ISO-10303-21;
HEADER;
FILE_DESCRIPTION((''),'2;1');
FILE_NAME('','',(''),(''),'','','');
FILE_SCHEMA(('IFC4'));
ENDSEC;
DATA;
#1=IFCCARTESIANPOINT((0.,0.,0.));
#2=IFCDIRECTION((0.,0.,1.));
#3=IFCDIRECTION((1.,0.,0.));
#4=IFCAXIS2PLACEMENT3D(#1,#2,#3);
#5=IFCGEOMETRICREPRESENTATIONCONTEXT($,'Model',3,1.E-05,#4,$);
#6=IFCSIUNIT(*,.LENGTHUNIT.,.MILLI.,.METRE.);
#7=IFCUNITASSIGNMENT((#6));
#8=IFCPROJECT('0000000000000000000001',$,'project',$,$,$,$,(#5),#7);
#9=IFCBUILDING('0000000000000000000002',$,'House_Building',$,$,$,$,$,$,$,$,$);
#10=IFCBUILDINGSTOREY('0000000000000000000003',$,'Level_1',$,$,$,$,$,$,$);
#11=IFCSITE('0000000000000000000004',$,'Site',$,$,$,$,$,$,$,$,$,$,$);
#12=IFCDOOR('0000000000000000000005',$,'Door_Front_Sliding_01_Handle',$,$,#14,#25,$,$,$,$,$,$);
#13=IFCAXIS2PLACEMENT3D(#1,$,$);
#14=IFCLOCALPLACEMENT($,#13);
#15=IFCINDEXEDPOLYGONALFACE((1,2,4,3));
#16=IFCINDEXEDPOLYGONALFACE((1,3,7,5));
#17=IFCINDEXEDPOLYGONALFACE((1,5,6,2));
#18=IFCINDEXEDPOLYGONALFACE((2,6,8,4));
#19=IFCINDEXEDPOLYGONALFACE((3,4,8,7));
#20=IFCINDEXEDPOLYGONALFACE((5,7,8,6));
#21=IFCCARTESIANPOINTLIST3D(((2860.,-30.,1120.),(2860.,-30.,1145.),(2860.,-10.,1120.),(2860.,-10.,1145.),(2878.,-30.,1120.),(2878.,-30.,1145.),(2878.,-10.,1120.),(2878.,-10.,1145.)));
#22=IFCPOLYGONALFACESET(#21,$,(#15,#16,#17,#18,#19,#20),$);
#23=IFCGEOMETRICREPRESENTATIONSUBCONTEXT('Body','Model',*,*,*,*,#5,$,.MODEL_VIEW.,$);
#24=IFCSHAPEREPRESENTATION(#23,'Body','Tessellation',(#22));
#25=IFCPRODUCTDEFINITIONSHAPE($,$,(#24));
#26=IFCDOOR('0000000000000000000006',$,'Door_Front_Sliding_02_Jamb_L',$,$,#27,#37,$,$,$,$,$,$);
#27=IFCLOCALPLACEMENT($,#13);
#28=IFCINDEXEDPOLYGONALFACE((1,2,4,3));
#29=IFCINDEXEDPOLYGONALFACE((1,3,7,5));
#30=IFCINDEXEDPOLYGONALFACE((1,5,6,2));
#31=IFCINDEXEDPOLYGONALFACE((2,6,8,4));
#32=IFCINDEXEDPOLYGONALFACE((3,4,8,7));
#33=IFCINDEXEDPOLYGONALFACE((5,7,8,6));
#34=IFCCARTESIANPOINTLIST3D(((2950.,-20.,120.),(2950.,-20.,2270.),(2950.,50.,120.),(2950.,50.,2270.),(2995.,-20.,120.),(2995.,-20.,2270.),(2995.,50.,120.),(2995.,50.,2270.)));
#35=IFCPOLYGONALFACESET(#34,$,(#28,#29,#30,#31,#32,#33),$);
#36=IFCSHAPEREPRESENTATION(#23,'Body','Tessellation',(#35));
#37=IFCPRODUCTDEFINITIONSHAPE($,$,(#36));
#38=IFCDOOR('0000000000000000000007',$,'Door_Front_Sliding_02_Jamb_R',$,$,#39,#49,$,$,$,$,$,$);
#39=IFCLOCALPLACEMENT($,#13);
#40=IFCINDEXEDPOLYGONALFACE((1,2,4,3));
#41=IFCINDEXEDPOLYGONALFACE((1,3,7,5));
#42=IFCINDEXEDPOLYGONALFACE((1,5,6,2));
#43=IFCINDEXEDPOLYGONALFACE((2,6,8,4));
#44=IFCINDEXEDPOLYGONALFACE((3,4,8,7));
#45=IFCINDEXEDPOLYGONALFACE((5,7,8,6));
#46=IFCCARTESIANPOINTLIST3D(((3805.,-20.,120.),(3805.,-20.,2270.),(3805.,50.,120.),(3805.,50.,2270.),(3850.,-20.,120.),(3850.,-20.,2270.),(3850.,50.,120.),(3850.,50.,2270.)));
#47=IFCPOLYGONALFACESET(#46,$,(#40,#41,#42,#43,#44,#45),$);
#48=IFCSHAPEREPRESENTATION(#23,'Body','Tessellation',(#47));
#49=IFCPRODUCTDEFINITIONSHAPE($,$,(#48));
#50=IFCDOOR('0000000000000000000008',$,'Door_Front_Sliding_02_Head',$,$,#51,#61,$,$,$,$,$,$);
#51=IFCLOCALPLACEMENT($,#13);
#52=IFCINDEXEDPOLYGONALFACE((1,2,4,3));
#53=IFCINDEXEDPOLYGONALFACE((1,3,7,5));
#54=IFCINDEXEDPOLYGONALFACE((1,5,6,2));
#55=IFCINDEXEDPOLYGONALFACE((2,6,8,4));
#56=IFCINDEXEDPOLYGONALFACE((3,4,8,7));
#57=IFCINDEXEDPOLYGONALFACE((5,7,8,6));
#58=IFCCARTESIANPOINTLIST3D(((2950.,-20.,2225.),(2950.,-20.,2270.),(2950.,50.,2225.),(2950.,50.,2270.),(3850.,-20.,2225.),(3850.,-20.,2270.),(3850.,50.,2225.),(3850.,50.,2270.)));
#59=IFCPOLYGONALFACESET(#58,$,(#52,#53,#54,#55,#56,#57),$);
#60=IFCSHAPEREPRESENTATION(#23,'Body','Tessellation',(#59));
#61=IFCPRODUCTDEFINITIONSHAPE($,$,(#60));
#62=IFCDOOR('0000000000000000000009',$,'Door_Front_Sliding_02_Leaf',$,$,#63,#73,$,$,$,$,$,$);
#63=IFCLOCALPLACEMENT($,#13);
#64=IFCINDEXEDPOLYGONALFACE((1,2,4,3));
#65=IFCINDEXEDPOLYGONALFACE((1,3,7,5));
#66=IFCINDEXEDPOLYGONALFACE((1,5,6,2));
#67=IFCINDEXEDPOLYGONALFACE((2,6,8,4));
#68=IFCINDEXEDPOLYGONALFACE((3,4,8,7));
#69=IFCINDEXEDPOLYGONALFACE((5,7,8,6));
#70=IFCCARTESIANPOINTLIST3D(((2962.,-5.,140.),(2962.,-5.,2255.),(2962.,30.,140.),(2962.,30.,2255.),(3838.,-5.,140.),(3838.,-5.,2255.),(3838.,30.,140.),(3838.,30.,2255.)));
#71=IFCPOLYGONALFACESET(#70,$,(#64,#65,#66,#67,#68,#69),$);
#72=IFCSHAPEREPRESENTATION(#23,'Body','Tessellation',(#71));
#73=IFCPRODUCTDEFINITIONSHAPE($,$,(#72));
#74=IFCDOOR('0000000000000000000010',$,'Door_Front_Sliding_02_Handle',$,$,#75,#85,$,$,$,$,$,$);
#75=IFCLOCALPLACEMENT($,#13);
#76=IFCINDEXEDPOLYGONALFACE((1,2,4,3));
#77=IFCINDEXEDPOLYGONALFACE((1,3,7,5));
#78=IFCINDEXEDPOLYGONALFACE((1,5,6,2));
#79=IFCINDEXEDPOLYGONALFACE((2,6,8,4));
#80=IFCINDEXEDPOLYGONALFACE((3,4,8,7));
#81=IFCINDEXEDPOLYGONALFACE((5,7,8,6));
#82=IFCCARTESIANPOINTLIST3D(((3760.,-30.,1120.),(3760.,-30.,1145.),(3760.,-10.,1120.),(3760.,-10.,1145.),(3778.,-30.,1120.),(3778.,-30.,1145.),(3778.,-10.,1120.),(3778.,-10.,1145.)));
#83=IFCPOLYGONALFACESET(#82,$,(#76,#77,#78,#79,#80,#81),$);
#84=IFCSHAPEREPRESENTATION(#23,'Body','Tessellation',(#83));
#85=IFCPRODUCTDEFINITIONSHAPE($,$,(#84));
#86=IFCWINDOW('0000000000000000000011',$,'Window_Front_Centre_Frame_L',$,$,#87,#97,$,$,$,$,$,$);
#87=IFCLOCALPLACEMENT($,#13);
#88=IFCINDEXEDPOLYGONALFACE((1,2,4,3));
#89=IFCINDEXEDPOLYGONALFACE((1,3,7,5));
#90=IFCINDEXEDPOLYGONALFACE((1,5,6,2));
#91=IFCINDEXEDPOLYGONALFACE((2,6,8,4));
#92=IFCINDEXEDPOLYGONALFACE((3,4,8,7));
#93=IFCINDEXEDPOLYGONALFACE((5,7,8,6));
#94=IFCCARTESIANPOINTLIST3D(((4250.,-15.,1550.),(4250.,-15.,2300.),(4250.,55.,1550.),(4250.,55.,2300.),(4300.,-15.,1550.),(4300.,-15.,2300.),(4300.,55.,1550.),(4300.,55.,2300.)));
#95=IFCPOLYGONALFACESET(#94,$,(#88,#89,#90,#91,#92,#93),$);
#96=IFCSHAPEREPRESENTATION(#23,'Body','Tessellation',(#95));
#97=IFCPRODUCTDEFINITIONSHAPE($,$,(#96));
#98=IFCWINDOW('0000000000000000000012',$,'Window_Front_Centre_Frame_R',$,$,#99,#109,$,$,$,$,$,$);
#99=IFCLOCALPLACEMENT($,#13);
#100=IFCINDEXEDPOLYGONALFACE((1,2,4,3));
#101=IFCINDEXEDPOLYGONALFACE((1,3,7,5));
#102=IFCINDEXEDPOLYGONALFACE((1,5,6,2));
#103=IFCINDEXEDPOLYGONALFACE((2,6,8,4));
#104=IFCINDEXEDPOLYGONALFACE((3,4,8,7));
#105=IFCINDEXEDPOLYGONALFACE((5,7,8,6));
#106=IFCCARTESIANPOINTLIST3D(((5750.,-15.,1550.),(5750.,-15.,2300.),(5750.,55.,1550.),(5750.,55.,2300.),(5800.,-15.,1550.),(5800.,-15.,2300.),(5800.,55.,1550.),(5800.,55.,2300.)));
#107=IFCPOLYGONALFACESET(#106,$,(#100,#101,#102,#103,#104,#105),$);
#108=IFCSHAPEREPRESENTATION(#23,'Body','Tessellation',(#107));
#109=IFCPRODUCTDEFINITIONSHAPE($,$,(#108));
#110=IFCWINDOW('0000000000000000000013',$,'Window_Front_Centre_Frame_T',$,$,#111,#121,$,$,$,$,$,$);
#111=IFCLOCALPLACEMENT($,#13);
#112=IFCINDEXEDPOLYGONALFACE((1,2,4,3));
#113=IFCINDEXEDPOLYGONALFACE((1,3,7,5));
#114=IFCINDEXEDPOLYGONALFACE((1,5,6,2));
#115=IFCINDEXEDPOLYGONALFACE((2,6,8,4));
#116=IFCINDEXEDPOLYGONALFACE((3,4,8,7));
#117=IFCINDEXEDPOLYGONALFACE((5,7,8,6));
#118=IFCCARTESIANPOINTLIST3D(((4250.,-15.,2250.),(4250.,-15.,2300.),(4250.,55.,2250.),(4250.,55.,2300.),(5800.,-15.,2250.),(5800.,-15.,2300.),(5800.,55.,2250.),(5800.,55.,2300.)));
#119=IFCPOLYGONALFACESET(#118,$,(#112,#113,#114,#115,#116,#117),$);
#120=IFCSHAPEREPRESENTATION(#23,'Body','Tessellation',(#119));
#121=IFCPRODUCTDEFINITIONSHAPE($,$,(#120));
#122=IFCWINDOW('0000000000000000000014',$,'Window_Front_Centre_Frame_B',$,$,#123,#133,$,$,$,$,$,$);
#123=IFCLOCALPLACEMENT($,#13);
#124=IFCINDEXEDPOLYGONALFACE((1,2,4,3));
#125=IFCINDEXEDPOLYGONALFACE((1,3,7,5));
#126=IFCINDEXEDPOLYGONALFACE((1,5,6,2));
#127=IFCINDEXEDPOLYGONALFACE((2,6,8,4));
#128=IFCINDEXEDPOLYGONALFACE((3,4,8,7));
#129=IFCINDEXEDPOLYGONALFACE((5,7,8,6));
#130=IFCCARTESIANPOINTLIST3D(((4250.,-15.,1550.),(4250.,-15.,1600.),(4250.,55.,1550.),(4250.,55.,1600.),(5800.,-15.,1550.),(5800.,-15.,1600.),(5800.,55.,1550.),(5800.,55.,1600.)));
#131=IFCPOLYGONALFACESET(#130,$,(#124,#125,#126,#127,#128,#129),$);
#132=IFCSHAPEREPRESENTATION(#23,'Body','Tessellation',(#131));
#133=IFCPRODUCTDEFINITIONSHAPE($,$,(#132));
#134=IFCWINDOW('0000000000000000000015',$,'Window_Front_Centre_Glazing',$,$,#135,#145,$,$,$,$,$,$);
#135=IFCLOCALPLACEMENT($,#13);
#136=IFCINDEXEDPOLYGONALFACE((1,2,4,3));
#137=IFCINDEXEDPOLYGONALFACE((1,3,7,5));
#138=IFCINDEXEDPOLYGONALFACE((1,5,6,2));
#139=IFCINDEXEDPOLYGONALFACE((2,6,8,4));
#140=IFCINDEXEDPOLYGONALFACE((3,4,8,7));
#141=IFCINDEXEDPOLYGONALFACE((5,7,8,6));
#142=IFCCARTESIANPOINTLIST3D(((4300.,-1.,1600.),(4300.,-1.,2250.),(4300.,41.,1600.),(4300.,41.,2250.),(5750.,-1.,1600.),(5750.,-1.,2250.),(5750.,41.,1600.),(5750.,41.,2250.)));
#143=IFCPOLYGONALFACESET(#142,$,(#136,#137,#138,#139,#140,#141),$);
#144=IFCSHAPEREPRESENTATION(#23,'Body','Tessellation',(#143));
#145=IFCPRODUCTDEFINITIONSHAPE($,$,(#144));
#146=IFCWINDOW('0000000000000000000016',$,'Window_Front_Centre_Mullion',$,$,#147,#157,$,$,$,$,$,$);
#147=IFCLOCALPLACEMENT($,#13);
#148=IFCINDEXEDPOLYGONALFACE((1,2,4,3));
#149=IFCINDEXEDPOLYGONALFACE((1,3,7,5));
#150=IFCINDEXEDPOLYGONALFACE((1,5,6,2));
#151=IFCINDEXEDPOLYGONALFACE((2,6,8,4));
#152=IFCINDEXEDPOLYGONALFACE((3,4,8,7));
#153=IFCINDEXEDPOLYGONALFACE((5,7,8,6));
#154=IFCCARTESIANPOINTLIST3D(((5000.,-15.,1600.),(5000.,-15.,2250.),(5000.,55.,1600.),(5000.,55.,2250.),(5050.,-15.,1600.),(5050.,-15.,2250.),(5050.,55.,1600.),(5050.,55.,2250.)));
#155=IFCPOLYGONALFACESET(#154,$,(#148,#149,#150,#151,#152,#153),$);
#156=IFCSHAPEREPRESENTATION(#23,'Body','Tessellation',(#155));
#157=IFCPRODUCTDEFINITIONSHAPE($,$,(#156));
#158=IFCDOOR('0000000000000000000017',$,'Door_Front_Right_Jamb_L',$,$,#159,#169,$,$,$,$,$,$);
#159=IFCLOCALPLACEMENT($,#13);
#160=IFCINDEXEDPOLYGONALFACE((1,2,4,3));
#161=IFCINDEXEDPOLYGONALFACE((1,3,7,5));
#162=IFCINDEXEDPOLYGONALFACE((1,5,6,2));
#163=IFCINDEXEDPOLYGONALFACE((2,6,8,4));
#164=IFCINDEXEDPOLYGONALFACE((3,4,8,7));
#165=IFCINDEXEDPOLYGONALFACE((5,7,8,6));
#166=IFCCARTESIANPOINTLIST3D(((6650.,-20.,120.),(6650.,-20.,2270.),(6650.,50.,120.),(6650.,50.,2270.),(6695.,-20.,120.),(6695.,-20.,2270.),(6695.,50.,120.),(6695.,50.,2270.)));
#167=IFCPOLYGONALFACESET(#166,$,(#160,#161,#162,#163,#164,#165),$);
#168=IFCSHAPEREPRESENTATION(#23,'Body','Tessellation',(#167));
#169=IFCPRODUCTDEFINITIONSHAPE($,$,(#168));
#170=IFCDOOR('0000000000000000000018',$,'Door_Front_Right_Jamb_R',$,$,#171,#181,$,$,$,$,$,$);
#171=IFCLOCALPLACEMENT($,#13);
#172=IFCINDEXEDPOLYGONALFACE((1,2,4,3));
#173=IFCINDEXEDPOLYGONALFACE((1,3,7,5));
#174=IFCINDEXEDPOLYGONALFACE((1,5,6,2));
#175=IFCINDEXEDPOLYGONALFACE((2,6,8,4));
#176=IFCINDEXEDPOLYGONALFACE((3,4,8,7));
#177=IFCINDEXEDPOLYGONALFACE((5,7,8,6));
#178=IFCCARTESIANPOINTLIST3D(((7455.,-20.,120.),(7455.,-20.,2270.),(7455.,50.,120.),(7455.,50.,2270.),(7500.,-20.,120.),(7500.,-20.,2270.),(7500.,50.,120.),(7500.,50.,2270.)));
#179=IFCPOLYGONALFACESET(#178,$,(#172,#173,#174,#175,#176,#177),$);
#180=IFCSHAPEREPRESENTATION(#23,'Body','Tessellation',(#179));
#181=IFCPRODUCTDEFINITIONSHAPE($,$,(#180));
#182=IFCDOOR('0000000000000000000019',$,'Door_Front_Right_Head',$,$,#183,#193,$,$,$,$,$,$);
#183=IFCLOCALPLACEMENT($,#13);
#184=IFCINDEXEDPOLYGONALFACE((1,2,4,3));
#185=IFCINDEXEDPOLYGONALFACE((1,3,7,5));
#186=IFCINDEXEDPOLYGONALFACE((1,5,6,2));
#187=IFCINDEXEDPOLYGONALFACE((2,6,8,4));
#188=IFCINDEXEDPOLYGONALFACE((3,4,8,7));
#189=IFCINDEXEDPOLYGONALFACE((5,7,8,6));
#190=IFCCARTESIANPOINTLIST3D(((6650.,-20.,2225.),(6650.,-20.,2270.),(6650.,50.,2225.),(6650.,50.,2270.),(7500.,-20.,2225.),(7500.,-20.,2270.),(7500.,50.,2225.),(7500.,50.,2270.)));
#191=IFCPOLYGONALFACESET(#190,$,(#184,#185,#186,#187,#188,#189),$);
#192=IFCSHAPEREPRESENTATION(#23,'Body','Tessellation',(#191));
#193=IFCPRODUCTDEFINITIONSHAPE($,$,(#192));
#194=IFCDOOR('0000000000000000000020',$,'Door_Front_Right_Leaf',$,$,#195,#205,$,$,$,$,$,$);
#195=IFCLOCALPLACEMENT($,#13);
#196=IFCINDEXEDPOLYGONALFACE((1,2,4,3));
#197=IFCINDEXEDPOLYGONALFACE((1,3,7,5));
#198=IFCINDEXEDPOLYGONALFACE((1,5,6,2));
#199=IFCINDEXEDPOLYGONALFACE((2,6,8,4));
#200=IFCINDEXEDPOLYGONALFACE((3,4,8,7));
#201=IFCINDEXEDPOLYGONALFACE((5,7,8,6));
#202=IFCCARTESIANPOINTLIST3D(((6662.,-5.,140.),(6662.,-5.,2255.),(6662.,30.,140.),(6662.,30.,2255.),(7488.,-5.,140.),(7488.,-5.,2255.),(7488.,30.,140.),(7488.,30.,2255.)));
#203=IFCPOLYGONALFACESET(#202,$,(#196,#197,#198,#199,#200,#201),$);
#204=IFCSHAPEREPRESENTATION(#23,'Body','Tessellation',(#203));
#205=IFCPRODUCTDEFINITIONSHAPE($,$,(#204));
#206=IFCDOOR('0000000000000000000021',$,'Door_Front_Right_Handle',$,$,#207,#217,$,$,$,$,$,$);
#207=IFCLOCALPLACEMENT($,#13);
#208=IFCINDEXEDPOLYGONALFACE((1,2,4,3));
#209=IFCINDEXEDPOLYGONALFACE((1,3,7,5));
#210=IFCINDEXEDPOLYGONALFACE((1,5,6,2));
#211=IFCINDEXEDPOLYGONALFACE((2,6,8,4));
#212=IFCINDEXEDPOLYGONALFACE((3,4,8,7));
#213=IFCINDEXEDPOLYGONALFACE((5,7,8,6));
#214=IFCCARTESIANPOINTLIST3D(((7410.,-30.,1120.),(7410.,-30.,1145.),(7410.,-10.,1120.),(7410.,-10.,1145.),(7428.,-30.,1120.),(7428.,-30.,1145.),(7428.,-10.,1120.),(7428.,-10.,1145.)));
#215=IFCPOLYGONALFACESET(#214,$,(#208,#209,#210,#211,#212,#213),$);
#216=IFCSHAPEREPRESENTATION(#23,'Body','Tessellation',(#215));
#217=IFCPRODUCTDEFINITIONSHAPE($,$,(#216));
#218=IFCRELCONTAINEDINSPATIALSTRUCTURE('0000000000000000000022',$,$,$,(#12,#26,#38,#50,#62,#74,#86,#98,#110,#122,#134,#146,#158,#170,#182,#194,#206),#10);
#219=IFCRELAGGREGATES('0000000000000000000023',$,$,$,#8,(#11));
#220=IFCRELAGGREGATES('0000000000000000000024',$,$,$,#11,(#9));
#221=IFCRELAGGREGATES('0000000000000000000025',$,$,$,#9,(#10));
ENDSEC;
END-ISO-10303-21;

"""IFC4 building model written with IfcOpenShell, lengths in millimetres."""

from ifc_helpers import new_model, si_unit, frame, origin_with_axes, context, subcontext, project, spatial, polyline, outline, extrude, element, save


model = new_model("IFC4")

# Units and contexts
model_context = context("Model", 3, precision=1e-05, world=origin_with_axes())
body_context = subcontext(model_context, "Body", "Model", "MODEL_VIEW")
ifc_project = project(units=[si_unit("LENGTHUNIT", "METRE", prefix="MILLI")], contexts=[model_context])

# Site, building, storey
site = spatial("IfcSite", under=ifc_project, Name="Site")
building = spatial("IfcBuilding", under=site, Name="House_Building")
storey = spatial("IfcBuildingStorey", under=building, Name="Level_1")

# Doors
element("IfcDoor", 1, inside=storey, Name="Door_Front_Sliding_01_Handle", context=body_context, shape_type="SweptSolid", body=[
    extrude(outline(polyline([(2860.0, -30.0), (2878.0, -30.0), (2878.0, -10.0), (2860.0, -10.0), (2860.0, -30.0)])), frame((0.0, 0.0, 1120.0), z_axis=(0.0, 0.0, 1.0), x_axis=(1.0, 0.0, 0.0)), (0.0, 0.0, 1.0), 25.0),
])
element("IfcDoor", 2, inside=storey, Name="Door_Front_Sliding_02_Jamb_L", context=body_context, shape_type="SweptSolid", body=[
    extrude(outline(polyline([(2950.0, -20.0), (2995.0, -20.0), (2995.0, 50.0), (2950.0, 50.0), (2950.0, -20.0)])), frame((0.0, 0.0, 120.0), z_axis=(0.0, 0.0, 1.0), x_axis=(1.0, 0.0, 0.0)), (0.0, 0.0, 1.0), 2150.0),
])
element("IfcDoor", 3, inside=storey, Name="Door_Front_Sliding_02_Jamb_R", context=body_context, shape_type="SweptSolid", body=[
    extrude(outline(polyline([(3805.0, -20.0), (3850.0, -20.0), (3850.0, 50.0), (3805.0, 50.0), (3805.0, -20.0)])), frame((0.0, 0.0, 120.0), z_axis=(0.0, 0.0, 1.0), x_axis=(1.0, 0.0, 0.0)), (0.0, 0.0, 1.0), 2150.0),
])
element("IfcDoor", 4, inside=storey, Name="Door_Front_Sliding_02_Head", context=body_context, shape_type="SweptSolid", body=[
    extrude(outline(polyline([(2950.0, -20.0), (3850.0, -20.0), (3850.0, 50.0), (2950.0, 50.0), (2950.0, -20.0)])), frame((0.0, 0.0, 2225.0), z_axis=(0.0, 0.0, 1.0), x_axis=(1.0, 0.0, 0.0)), (0.0, 0.0, 1.0), 45.0),
])
element("IfcDoor", 5, inside=storey, Name="Door_Front_Sliding_02_Leaf", context=body_context, shape_type="SweptSolid", body=[
    extrude(outline(polyline([(2962.0, -5.0), (3838.0, -5.0), (3838.0, 30.0), (2962.0, 30.0), (2962.0, -5.0)])), frame((0.0, 0.0, 140.0), z_axis=(0.0, 0.0, 1.0), x_axis=(1.0, 0.0, 0.0)), (0.0, 0.0, 1.0), 2115.0),
])
element("IfcDoor", 6, inside=storey, Name="Door_Front_Sliding_02_Handle", context=body_context, shape_type="SweptSolid", body=[
    extrude(outline(polyline([(3760.0, -30.0), (3778.0, -30.0), (3778.0, -10.0), (3760.0, -10.0), (3760.0, -30.0)])), frame((0.0, 0.0, 1120.0), z_axis=(0.0, 0.0, 1.0), x_axis=(1.0, 0.0, 0.0)), (0.0, 0.0, 1.0), 25.0),
])

# Windows
element("IfcWindow", 7, inside=storey, Name="Window_Front_Centre_Frame_L", context=body_context, shape_type="SweptSolid", body=[
    extrude(outline(polyline([(4250.0, -15.0), (4300.0, -15.0), (4300.0, 55.0), (4250.0, 55.0), (4250.0, -15.0)])), frame((0.0, 0.0, 1550.0), z_axis=(0.0, 0.0, 1.0), x_axis=(1.0, 0.0, 0.0)), (0.0, 0.0, 1.0), 750.0),
])
element("IfcWindow", 8, inside=storey, Name="Window_Front_Centre_Frame_R", context=body_context, shape_type="SweptSolid", body=[
    extrude(outline(polyline([(5750.0, -15.0), (5800.0, -15.0), (5800.0, 55.0), (5750.0, 55.0), (5750.0, -15.0)])), frame((0.0, 0.0, 1550.0), z_axis=(0.0, 0.0, 1.0), x_axis=(1.0, 0.0, 0.0)), (0.0, 0.0, 1.0), 750.0),
])
element("IfcWindow", 9, inside=storey, Name="Window_Front_Centre_Frame_T", context=body_context, shape_type="SweptSolid", body=[
    extrude(outline(polyline([(4250.0, -15.0), (5800.0, -15.0), (5800.0, 55.0), (4250.0, 55.0), (4250.0, -15.0)])), frame((0.0, 0.0, 2250.0), z_axis=(0.0, 0.0, 1.0), x_axis=(1.0, 0.0, 0.0)), (0.0, 0.0, 1.0), 50.0),
])
element("IfcWindow", 10, inside=storey, Name="Window_Front_Centre_Frame_B", context=body_context, shape_type="SweptSolid", body=[
    extrude(outline(polyline([(4250.0, -15.0), (5800.0, -15.0), (5800.0, 55.0), (4250.0, 55.0), (4250.0, -15.0)])), frame((0.0, 0.0, 1550.0), z_axis=(0.0, 0.0, 1.0), x_axis=(1.0, 0.0, 0.0)), (0.0, 0.0, 1.0), 50.0),
])
element("IfcWindow", 11, inside=storey, Name="Window_Front_Centre_Glazing", context=body_context, shape_type="SweptSolid", body=[
    extrude(outline(polyline([(4300.0, -1.0), (5750.0, -1.0), (5750.0, 41.0), (4300.0, 41.0), (4300.0, -1.0)])), frame((0.0, 0.0, 1600.0), z_axis=(0.0, 0.0, 1.0), x_axis=(1.0, 0.0, 0.0)), (0.0, 0.0, 1.0), 650.0),
])
element("IfcWindow", 12, inside=storey, Name="Window_Front_Centre_Mullion", context=body_context, shape_type="SweptSolid", body=[
    extrude(outline(polyline([(5000.0, -15.0), (5050.0, -15.0), (5050.0, 55.0), (5000.0, 55.0), (5000.0, -15.0)])), frame((0.0, 0.0, 1600.0), z_axis=(0.0, 0.0, 1.0), x_axis=(1.0, 0.0, 0.0)), (0.0, 0.0, 1.0), 650.0),
])

# Doors
element("IfcDoor", 13, inside=storey, Name="Door_Front_Right_Jamb_L", context=body_context, shape_type="SweptSolid", body=[
    extrude(outline(polyline([(6650.0, -20.0), (6695.0, -20.0), (6695.0, 50.0), (6650.0, 50.0), (6650.0, -20.0)])), frame((0.0, 0.0, 120.0), z_axis=(0.0, 0.0, 1.0), x_axis=(1.0, 0.0, 0.0)), (0.0, 0.0, 1.0), 2150.0),
])
element("IfcDoor", 14, inside=storey, Name="Door_Front_Right_Jamb_R", context=body_context, shape_type="SweptSolid", body=[
    extrude(outline(polyline([(7455.0, -20.0), (7500.0, -20.0), (7500.0, 50.0), (7455.0, 50.0), (7455.0, -20.0)])), frame((0.0, 0.0, 120.0), z_axis=(0.0, 0.0, 1.0), x_axis=(1.0, 0.0, 0.0)), (0.0, 0.0, 1.0), 2150.0),
])
element("IfcDoor", 15, inside=storey, Name="Door_Front_Right_Head", context=body_context, shape_type="SweptSolid", body=[
    extrude(outline(polyline([(6650.0, -20.0), (7500.0, -20.0), (7500.0, 50.0), (6650.0, 50.0), (6650.0, -20.0)])), frame((0.0, 0.0, 2225.0), z_axis=(0.0, 0.0, 1.0), x_axis=(1.0, 0.0, 0.0)), (0.0, 0.0, 1.0), 45.0),
])
element("IfcDoor", 16, inside=storey, Name="Door_Front_Right_Leaf", context=body_context, shape_type="SweptSolid", body=[
    extrude(outline(polyline([(6662.0, -5.0), (7488.0, -5.0), (7488.0, 30.0), (6662.0, 30.0), (6662.0, -5.0)])), frame((0.0, 0.0, 140.0), z_axis=(0.0, 0.0, 1.0), x_axis=(1.0, 0.0, 0.0)), (0.0, 0.0, 1.0), 2115.0),
])
element("IfcDoor", 17, inside=storey, Name="Door_Front_Right_Handle", context=body_context, shape_type="SweptSolid", body=[
    extrude(outline(polyline([(7410.0, -30.0), (7428.0, -30.0), (7428.0, -10.0), (7410.0, -10.0), (7410.0, -30.0)])), frame((0.0, 0.0, 1120.0), z_axis=(0.0, 0.0, 1.0), x_axis=(1.0, 0.0, 0.0)), (0.0, 0.0, 1.0), 25.0),
])

save(model, "model.ifc")
